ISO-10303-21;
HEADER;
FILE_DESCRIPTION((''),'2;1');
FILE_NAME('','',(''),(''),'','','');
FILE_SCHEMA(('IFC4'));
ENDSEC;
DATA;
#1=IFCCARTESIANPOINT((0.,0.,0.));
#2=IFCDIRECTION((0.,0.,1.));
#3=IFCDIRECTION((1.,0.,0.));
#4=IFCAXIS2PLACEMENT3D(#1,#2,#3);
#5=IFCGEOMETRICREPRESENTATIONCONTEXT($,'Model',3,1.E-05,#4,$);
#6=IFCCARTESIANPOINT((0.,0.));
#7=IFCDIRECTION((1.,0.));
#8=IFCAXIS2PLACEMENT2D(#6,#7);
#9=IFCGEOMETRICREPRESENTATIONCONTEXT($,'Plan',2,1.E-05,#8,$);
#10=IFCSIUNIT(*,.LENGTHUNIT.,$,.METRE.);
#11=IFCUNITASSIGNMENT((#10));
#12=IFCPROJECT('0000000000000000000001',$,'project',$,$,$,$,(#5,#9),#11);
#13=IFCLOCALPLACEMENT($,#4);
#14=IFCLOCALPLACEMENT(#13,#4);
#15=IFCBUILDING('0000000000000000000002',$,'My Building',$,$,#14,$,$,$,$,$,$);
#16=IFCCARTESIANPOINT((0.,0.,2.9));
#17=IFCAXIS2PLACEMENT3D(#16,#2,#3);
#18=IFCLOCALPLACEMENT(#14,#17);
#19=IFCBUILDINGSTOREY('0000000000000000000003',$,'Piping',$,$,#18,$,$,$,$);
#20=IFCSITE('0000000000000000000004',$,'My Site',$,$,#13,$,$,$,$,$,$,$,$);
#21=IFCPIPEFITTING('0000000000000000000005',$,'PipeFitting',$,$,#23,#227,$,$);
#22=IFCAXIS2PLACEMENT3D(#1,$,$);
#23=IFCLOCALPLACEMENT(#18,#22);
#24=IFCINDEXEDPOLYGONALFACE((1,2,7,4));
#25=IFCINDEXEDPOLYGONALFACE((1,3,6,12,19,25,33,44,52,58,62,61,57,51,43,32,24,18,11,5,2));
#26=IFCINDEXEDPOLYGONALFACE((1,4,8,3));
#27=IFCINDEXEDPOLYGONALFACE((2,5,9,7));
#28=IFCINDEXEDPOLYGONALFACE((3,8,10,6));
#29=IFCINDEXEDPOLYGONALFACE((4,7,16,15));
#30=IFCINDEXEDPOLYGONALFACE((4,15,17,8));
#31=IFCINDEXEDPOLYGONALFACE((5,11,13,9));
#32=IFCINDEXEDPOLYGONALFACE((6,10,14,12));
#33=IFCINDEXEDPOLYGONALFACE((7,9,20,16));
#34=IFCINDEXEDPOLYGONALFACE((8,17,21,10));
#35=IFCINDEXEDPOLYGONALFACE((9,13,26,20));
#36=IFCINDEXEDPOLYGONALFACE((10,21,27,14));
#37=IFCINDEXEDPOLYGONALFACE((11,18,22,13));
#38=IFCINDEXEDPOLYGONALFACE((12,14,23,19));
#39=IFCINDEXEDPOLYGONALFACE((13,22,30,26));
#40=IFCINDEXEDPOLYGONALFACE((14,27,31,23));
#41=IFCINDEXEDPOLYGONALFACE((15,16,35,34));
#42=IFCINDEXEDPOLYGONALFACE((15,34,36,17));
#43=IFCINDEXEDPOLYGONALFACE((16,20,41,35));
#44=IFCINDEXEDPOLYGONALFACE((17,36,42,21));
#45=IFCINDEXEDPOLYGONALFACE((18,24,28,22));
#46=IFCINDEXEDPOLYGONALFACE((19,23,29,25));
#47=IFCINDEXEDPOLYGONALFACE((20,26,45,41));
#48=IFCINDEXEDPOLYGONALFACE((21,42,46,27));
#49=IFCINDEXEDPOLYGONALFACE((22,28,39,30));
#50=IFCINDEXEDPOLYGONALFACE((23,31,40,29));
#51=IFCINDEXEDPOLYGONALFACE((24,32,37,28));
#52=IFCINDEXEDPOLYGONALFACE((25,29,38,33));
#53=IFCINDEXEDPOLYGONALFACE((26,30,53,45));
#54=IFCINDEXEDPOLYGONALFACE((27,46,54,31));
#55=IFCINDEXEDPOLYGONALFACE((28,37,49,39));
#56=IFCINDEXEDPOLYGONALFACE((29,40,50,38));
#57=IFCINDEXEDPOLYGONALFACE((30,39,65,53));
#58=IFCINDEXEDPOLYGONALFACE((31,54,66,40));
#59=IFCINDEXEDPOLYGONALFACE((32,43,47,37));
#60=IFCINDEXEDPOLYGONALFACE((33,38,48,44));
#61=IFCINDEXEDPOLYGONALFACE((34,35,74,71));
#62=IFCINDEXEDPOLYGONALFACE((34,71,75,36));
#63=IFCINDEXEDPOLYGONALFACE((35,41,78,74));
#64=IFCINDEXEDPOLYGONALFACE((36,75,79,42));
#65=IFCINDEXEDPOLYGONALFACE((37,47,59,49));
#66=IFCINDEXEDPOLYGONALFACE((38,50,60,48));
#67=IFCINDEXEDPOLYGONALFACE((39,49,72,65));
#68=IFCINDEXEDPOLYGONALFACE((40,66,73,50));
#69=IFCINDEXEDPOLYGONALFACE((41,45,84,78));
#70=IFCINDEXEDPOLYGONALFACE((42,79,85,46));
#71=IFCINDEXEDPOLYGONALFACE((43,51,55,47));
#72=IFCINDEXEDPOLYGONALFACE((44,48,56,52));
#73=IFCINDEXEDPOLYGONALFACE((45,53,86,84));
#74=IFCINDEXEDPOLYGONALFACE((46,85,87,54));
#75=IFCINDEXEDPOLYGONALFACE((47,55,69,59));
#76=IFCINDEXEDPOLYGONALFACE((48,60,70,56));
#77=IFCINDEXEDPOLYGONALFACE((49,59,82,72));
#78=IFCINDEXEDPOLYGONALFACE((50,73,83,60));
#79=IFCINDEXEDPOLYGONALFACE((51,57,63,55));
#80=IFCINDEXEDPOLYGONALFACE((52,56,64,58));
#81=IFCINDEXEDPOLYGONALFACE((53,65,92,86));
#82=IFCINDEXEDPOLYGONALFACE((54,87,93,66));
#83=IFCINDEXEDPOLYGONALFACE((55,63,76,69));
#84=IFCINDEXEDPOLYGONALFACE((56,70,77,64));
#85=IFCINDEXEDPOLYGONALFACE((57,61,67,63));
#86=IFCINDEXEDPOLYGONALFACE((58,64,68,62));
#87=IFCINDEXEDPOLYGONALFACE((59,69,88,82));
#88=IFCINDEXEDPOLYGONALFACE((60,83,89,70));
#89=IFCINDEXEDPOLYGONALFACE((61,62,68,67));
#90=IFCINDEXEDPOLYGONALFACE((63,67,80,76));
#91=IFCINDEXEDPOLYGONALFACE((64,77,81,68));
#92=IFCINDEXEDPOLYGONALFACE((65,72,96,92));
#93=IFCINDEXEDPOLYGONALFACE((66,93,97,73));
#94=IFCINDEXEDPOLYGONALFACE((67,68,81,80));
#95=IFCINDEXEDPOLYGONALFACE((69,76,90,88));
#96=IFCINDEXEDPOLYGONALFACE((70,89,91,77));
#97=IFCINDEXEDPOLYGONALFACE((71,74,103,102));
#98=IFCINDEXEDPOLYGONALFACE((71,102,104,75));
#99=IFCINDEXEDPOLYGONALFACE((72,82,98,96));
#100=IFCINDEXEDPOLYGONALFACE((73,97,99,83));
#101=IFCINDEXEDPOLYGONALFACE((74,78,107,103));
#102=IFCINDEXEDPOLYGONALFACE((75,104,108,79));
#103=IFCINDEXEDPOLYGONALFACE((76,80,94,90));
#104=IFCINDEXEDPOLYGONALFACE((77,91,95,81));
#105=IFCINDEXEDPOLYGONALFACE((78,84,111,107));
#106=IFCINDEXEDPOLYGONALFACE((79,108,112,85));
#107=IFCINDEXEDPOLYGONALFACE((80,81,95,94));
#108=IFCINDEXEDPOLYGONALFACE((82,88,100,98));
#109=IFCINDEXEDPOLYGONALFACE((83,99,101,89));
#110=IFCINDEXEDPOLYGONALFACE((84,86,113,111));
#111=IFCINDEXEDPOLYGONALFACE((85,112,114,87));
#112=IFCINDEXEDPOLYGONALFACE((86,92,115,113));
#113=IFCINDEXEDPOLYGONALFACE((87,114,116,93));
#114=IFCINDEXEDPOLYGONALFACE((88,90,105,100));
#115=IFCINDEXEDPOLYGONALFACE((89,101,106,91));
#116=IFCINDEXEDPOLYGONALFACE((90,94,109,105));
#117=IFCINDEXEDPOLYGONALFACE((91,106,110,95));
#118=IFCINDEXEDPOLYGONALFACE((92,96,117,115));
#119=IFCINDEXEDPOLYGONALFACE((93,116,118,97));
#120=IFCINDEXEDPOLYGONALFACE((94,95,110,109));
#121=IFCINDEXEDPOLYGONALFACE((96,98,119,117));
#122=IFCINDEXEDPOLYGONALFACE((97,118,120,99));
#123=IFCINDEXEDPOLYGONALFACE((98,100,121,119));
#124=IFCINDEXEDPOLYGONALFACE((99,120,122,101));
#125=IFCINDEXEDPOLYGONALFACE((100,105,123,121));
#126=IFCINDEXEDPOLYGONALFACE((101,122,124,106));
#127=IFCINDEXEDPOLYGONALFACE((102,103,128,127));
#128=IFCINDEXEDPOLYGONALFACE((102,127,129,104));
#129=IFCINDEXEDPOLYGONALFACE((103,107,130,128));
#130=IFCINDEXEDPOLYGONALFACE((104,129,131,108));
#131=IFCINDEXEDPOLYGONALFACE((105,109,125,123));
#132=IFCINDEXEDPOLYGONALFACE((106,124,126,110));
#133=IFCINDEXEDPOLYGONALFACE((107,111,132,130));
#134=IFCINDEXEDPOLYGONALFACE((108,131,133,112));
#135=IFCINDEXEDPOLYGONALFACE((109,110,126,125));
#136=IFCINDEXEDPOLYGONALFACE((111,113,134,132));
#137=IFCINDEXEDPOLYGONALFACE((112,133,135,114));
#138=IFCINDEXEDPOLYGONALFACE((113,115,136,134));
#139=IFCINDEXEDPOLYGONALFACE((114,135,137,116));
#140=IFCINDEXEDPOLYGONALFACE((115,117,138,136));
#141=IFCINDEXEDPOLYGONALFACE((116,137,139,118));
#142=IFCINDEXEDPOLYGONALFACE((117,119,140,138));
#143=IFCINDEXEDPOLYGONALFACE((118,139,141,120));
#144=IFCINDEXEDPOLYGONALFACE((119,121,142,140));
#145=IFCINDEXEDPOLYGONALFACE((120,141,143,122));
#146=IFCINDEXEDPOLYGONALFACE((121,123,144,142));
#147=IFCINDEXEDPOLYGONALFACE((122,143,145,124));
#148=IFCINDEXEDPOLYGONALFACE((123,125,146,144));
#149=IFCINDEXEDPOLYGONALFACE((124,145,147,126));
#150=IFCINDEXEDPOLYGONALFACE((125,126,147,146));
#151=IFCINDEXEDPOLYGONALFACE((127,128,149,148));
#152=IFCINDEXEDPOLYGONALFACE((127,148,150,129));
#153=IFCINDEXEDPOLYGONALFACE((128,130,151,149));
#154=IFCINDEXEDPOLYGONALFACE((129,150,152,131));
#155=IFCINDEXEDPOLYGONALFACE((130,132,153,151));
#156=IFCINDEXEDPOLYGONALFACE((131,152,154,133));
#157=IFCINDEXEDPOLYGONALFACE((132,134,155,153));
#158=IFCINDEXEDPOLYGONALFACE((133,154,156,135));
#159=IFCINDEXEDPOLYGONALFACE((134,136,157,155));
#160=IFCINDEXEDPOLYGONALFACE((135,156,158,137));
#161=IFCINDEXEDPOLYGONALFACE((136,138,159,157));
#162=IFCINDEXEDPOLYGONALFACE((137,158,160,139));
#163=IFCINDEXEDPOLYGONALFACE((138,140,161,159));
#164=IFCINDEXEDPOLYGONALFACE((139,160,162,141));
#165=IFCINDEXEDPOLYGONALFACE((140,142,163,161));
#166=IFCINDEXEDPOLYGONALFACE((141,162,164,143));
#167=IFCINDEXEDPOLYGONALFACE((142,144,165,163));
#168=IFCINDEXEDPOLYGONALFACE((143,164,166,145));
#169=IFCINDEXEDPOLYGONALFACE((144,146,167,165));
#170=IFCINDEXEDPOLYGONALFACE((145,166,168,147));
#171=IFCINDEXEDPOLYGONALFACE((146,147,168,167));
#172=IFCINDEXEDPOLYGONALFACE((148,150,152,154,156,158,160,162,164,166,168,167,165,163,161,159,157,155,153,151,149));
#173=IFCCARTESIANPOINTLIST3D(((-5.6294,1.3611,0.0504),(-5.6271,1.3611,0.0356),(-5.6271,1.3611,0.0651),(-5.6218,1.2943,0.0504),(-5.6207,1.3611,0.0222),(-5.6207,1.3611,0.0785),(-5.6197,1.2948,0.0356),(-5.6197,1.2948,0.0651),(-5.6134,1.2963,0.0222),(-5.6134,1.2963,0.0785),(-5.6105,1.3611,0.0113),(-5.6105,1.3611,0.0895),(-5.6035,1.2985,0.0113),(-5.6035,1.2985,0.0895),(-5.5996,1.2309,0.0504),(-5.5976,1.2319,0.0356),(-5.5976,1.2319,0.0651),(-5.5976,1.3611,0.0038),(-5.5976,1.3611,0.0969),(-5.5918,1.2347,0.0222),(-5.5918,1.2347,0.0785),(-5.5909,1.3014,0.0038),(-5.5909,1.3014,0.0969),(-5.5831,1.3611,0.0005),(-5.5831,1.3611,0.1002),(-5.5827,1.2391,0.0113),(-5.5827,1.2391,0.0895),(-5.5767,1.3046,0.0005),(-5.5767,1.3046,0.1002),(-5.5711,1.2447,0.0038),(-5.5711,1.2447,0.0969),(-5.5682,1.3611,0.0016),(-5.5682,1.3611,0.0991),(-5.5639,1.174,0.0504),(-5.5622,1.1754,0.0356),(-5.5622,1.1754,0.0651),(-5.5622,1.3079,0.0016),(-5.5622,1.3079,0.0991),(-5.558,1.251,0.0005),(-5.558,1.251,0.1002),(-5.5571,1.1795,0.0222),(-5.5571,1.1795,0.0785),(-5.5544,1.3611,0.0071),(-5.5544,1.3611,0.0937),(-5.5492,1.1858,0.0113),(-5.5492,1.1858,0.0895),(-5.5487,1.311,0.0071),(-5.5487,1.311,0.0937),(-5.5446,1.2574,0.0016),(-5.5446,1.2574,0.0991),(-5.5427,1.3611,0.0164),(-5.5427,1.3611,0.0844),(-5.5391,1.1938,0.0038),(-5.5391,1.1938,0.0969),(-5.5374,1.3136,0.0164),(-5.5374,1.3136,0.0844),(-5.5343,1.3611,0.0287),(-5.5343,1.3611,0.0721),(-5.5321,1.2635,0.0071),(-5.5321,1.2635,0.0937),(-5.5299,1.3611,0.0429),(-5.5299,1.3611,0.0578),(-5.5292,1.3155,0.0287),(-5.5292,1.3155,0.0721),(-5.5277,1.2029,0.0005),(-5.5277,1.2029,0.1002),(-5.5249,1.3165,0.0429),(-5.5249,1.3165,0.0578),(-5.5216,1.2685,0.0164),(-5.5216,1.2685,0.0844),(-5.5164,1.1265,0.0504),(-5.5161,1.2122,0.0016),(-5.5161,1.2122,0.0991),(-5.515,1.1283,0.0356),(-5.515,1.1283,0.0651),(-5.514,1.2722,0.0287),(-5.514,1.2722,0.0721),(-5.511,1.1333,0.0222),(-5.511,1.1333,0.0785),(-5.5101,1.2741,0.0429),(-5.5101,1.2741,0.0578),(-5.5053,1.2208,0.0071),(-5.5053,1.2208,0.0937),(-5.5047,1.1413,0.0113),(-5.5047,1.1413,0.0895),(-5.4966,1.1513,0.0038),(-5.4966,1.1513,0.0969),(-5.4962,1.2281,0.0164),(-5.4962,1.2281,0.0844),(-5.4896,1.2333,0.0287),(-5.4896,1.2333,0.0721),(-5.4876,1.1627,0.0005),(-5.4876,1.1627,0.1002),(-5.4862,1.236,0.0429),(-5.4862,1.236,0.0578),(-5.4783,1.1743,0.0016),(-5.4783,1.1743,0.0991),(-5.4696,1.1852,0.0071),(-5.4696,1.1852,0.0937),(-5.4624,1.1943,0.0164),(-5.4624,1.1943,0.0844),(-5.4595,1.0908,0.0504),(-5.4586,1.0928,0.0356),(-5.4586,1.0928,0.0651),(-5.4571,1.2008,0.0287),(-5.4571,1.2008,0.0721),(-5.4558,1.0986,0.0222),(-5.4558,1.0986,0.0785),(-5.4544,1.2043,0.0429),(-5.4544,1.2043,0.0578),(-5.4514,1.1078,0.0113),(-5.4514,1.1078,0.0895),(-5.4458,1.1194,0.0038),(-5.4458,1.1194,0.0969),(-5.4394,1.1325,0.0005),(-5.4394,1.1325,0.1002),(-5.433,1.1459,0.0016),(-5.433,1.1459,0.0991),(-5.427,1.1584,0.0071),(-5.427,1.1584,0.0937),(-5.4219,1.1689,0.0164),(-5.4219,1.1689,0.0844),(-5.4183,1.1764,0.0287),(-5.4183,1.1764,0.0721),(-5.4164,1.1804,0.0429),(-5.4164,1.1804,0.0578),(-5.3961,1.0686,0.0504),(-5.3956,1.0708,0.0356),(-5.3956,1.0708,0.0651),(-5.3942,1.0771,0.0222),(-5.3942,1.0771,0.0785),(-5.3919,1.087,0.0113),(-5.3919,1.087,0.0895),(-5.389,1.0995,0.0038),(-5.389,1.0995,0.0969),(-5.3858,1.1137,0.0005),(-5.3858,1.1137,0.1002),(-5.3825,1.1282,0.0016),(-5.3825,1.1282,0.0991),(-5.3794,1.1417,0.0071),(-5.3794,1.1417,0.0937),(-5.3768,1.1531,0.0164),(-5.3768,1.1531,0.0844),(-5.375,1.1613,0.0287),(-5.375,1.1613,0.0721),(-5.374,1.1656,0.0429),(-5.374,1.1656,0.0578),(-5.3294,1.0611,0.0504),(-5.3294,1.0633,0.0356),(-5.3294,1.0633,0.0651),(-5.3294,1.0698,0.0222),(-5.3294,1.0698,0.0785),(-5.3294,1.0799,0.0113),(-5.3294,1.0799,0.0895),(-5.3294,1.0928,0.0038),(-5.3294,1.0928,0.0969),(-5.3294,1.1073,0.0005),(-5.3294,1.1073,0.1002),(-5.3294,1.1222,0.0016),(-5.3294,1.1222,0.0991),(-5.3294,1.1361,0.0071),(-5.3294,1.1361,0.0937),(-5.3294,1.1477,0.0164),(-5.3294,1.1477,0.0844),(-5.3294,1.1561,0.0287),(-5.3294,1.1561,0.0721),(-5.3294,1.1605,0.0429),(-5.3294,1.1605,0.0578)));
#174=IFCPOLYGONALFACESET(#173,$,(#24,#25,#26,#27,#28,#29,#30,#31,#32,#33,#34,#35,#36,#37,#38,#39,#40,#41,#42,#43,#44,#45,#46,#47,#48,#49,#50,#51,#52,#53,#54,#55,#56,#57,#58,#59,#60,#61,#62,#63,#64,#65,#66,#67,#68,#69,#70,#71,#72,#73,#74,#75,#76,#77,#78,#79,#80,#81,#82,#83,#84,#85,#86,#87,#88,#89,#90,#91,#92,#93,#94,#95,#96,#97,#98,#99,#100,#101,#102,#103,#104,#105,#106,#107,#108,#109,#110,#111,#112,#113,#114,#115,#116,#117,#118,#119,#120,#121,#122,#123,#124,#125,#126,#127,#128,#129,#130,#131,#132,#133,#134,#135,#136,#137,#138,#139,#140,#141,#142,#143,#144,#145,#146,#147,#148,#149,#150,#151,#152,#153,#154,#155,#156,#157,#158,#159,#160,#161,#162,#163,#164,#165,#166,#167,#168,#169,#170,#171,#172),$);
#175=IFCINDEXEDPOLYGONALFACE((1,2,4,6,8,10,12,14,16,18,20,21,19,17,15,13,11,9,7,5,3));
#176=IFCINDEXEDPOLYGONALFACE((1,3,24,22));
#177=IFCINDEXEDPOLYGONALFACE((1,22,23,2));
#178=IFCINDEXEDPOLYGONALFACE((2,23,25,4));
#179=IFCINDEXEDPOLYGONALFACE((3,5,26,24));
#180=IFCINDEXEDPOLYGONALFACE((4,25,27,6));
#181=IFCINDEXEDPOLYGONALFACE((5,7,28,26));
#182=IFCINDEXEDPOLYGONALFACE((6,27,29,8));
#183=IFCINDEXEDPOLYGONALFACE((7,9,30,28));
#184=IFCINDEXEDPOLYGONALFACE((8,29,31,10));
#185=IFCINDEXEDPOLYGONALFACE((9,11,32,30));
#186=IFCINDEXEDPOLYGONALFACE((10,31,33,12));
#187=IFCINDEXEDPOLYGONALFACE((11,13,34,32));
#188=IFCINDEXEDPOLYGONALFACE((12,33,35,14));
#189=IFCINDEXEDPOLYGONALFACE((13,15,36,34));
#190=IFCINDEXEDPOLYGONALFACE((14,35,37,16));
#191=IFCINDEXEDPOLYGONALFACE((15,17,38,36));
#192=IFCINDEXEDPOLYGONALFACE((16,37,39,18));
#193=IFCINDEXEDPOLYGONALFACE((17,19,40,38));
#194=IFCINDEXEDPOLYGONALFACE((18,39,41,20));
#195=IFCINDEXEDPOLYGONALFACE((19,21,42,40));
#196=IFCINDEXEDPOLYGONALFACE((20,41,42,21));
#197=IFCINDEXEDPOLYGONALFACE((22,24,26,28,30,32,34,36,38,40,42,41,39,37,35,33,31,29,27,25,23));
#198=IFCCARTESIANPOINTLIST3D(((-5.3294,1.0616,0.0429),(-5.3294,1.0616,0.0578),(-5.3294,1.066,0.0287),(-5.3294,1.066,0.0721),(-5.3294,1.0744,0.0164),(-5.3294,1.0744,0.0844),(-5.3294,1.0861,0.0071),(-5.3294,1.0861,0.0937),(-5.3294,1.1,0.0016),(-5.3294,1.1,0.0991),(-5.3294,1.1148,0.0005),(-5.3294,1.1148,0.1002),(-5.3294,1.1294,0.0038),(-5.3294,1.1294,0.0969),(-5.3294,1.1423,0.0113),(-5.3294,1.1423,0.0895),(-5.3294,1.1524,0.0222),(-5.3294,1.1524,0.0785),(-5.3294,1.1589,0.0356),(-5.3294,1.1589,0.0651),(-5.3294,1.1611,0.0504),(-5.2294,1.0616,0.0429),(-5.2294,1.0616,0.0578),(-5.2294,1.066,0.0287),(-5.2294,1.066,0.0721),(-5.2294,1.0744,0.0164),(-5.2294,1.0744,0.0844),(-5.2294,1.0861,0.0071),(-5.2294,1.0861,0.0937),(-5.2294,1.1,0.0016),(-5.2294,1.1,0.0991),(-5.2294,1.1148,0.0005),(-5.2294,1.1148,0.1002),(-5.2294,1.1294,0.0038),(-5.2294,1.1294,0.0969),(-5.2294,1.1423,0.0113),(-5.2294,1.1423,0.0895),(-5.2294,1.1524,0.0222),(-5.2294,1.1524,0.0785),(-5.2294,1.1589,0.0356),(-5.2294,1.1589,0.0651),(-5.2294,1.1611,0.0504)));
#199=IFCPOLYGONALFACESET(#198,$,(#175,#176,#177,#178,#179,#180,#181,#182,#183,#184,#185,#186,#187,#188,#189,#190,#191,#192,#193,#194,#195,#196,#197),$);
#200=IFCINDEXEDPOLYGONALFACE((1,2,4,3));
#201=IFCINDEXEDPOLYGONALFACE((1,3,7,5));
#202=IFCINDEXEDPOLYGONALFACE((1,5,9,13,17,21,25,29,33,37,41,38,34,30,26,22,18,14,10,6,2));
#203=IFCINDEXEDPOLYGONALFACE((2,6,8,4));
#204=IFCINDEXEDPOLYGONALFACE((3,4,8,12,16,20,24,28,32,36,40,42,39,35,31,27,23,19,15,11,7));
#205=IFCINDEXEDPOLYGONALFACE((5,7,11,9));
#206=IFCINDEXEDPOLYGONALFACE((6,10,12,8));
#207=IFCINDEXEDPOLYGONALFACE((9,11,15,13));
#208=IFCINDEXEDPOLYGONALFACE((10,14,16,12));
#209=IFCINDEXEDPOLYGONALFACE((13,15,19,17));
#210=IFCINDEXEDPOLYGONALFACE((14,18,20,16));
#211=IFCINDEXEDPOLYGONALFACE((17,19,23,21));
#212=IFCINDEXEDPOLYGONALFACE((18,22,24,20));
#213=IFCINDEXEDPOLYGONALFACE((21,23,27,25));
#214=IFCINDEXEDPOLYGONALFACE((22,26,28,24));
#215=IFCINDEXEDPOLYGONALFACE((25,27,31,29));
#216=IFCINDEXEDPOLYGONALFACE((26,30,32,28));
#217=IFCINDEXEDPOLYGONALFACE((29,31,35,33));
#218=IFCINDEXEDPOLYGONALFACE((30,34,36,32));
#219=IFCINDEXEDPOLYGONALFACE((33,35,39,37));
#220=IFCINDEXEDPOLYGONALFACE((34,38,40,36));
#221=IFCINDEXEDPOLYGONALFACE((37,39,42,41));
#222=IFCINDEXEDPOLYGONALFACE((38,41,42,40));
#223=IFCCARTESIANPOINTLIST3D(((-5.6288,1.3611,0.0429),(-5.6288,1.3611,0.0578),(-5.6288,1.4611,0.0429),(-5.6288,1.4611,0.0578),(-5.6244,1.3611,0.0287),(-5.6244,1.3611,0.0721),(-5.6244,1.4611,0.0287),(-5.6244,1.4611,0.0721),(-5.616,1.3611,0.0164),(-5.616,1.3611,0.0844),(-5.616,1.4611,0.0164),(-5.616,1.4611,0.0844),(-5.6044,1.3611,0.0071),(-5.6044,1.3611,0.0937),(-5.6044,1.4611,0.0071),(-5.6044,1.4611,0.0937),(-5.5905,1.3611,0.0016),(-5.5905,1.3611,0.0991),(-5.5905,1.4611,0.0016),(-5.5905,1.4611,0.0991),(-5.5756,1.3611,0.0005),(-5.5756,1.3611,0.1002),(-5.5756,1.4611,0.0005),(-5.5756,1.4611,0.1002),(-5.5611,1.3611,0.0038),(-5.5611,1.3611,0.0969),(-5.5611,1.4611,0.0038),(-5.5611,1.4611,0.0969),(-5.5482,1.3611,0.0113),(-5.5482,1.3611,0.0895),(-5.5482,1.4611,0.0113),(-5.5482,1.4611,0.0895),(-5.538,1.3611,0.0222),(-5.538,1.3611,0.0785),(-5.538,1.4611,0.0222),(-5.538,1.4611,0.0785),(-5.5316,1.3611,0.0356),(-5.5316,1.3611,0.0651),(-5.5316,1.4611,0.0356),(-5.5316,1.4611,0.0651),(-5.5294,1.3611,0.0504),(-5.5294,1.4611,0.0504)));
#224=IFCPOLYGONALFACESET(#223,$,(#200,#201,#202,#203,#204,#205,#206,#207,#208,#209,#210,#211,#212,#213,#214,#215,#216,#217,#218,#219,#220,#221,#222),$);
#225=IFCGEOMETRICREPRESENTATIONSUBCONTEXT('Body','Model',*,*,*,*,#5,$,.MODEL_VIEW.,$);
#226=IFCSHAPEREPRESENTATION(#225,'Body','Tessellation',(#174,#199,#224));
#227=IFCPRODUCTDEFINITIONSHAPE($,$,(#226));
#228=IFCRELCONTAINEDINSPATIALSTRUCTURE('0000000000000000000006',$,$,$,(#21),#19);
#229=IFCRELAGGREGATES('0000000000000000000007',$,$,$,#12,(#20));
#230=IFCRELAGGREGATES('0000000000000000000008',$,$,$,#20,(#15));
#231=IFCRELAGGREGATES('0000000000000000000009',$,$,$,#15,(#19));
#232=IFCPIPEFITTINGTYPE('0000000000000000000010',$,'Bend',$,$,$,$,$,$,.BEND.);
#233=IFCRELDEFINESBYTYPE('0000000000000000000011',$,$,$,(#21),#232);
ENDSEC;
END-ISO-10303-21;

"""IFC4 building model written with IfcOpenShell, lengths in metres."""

from ifc_helpers import new_model, entity, si_unit, frame, origin_with_axes, origin_2d_with_axis, place, context, subcontext, project, spatial, circle, extrude, source, transform, mapped, type_object, type_shapes, element, save


model = new_model("IFC4")

# Units and contexts
model_context = context("Model", 3, precision=1e-05, world=origin_with_axes())
plan_context = context("Plan", 2, precision=1e-05, world=origin_2d_with_axis())
body_context = subcontext(model_context, "Body", "Model", "MODEL_VIEW")
ifc_project = project(units=[si_unit("LENGTHUNIT", "METRE")], contexts=[model_context, plan_context])

# Site, building, storey
site_placement = place(None, origin_with_axes())
site = spatial("IfcSite", under=ifc_project, at=site_placement, Name="My Site")
building_placement = place(site_placement, origin_with_axes())
building = spatial("IfcBuilding", under=site, at=building_placement, Name="My Building")
storey_placement = place(building_placement, frame((0.0, 0.0, 2.9), z_axis=(0.0, 0.0, 1.0), x_axis=(1.0, 0.0, 0.0)))
storey = spatial("IfcBuildingStorey", under=building, at=storey_placement, Name="Piping")

# Pipe fitting
pipe_fitting_type_1 = type_object("IfcPipeFittingType", Name="Bend", PredefinedType="BEND")
shared_shape = source(origin_with_axes(), body_context, "Body", "SolidModel", [
    entity("IfcSweptDiskSolid", entity("IfcIndexedPolyCurve", entity("IfcCartesianPointList3D", [[0.0, 0.0, -0.1], [0.0732, 0.0, -0.2768], [0.25, 0.0, -0.35]]), [entity("IfcArcIndex", [1, 2, 3])]), 0.05),
    extrude(circle(Radius=0.05), origin_with_axes(), (0.0, 0.0, -1.0), 0.1),
    extrude(circle(Radius=0.05), frame((0.25, 0.0, -0.35), z_axis=(1.0, 0.0, 0.0), x_axis=(0.0, 0.0, 1.0)), (0.0, 0.0, 1.0), 0.1),
])
type_shapes(pipe_fitting_type_1, [shared_shape])
for number, where, z_axis, x_axis, name in (
    (1, (-5.2294, 1.1111, 0.0504), (1.0, -0.000001, 0.000001), (0.000001, 1.0, 0.0), "PipeFitting"),
):
    element("IfcPipeFitting", number, at=place(storey_placement, frame(where, z_axis=z_axis, x_axis=x_axis)), inside=storey, type_object=pipe_fitting_type_1, Name=name, context=body_context, shape_type="MappedRepresentation", body=[
        mapped(shared_shape, transform((0.0, 0.0, 0.0), x_axis=(1.0, 0.0, 0.0), y_axis=(0.0, 1.0, 0.0), z_axis=(0.0, 0.0, 1.0), scale=1.0)),
    ])

save(model, "model.ifc")
